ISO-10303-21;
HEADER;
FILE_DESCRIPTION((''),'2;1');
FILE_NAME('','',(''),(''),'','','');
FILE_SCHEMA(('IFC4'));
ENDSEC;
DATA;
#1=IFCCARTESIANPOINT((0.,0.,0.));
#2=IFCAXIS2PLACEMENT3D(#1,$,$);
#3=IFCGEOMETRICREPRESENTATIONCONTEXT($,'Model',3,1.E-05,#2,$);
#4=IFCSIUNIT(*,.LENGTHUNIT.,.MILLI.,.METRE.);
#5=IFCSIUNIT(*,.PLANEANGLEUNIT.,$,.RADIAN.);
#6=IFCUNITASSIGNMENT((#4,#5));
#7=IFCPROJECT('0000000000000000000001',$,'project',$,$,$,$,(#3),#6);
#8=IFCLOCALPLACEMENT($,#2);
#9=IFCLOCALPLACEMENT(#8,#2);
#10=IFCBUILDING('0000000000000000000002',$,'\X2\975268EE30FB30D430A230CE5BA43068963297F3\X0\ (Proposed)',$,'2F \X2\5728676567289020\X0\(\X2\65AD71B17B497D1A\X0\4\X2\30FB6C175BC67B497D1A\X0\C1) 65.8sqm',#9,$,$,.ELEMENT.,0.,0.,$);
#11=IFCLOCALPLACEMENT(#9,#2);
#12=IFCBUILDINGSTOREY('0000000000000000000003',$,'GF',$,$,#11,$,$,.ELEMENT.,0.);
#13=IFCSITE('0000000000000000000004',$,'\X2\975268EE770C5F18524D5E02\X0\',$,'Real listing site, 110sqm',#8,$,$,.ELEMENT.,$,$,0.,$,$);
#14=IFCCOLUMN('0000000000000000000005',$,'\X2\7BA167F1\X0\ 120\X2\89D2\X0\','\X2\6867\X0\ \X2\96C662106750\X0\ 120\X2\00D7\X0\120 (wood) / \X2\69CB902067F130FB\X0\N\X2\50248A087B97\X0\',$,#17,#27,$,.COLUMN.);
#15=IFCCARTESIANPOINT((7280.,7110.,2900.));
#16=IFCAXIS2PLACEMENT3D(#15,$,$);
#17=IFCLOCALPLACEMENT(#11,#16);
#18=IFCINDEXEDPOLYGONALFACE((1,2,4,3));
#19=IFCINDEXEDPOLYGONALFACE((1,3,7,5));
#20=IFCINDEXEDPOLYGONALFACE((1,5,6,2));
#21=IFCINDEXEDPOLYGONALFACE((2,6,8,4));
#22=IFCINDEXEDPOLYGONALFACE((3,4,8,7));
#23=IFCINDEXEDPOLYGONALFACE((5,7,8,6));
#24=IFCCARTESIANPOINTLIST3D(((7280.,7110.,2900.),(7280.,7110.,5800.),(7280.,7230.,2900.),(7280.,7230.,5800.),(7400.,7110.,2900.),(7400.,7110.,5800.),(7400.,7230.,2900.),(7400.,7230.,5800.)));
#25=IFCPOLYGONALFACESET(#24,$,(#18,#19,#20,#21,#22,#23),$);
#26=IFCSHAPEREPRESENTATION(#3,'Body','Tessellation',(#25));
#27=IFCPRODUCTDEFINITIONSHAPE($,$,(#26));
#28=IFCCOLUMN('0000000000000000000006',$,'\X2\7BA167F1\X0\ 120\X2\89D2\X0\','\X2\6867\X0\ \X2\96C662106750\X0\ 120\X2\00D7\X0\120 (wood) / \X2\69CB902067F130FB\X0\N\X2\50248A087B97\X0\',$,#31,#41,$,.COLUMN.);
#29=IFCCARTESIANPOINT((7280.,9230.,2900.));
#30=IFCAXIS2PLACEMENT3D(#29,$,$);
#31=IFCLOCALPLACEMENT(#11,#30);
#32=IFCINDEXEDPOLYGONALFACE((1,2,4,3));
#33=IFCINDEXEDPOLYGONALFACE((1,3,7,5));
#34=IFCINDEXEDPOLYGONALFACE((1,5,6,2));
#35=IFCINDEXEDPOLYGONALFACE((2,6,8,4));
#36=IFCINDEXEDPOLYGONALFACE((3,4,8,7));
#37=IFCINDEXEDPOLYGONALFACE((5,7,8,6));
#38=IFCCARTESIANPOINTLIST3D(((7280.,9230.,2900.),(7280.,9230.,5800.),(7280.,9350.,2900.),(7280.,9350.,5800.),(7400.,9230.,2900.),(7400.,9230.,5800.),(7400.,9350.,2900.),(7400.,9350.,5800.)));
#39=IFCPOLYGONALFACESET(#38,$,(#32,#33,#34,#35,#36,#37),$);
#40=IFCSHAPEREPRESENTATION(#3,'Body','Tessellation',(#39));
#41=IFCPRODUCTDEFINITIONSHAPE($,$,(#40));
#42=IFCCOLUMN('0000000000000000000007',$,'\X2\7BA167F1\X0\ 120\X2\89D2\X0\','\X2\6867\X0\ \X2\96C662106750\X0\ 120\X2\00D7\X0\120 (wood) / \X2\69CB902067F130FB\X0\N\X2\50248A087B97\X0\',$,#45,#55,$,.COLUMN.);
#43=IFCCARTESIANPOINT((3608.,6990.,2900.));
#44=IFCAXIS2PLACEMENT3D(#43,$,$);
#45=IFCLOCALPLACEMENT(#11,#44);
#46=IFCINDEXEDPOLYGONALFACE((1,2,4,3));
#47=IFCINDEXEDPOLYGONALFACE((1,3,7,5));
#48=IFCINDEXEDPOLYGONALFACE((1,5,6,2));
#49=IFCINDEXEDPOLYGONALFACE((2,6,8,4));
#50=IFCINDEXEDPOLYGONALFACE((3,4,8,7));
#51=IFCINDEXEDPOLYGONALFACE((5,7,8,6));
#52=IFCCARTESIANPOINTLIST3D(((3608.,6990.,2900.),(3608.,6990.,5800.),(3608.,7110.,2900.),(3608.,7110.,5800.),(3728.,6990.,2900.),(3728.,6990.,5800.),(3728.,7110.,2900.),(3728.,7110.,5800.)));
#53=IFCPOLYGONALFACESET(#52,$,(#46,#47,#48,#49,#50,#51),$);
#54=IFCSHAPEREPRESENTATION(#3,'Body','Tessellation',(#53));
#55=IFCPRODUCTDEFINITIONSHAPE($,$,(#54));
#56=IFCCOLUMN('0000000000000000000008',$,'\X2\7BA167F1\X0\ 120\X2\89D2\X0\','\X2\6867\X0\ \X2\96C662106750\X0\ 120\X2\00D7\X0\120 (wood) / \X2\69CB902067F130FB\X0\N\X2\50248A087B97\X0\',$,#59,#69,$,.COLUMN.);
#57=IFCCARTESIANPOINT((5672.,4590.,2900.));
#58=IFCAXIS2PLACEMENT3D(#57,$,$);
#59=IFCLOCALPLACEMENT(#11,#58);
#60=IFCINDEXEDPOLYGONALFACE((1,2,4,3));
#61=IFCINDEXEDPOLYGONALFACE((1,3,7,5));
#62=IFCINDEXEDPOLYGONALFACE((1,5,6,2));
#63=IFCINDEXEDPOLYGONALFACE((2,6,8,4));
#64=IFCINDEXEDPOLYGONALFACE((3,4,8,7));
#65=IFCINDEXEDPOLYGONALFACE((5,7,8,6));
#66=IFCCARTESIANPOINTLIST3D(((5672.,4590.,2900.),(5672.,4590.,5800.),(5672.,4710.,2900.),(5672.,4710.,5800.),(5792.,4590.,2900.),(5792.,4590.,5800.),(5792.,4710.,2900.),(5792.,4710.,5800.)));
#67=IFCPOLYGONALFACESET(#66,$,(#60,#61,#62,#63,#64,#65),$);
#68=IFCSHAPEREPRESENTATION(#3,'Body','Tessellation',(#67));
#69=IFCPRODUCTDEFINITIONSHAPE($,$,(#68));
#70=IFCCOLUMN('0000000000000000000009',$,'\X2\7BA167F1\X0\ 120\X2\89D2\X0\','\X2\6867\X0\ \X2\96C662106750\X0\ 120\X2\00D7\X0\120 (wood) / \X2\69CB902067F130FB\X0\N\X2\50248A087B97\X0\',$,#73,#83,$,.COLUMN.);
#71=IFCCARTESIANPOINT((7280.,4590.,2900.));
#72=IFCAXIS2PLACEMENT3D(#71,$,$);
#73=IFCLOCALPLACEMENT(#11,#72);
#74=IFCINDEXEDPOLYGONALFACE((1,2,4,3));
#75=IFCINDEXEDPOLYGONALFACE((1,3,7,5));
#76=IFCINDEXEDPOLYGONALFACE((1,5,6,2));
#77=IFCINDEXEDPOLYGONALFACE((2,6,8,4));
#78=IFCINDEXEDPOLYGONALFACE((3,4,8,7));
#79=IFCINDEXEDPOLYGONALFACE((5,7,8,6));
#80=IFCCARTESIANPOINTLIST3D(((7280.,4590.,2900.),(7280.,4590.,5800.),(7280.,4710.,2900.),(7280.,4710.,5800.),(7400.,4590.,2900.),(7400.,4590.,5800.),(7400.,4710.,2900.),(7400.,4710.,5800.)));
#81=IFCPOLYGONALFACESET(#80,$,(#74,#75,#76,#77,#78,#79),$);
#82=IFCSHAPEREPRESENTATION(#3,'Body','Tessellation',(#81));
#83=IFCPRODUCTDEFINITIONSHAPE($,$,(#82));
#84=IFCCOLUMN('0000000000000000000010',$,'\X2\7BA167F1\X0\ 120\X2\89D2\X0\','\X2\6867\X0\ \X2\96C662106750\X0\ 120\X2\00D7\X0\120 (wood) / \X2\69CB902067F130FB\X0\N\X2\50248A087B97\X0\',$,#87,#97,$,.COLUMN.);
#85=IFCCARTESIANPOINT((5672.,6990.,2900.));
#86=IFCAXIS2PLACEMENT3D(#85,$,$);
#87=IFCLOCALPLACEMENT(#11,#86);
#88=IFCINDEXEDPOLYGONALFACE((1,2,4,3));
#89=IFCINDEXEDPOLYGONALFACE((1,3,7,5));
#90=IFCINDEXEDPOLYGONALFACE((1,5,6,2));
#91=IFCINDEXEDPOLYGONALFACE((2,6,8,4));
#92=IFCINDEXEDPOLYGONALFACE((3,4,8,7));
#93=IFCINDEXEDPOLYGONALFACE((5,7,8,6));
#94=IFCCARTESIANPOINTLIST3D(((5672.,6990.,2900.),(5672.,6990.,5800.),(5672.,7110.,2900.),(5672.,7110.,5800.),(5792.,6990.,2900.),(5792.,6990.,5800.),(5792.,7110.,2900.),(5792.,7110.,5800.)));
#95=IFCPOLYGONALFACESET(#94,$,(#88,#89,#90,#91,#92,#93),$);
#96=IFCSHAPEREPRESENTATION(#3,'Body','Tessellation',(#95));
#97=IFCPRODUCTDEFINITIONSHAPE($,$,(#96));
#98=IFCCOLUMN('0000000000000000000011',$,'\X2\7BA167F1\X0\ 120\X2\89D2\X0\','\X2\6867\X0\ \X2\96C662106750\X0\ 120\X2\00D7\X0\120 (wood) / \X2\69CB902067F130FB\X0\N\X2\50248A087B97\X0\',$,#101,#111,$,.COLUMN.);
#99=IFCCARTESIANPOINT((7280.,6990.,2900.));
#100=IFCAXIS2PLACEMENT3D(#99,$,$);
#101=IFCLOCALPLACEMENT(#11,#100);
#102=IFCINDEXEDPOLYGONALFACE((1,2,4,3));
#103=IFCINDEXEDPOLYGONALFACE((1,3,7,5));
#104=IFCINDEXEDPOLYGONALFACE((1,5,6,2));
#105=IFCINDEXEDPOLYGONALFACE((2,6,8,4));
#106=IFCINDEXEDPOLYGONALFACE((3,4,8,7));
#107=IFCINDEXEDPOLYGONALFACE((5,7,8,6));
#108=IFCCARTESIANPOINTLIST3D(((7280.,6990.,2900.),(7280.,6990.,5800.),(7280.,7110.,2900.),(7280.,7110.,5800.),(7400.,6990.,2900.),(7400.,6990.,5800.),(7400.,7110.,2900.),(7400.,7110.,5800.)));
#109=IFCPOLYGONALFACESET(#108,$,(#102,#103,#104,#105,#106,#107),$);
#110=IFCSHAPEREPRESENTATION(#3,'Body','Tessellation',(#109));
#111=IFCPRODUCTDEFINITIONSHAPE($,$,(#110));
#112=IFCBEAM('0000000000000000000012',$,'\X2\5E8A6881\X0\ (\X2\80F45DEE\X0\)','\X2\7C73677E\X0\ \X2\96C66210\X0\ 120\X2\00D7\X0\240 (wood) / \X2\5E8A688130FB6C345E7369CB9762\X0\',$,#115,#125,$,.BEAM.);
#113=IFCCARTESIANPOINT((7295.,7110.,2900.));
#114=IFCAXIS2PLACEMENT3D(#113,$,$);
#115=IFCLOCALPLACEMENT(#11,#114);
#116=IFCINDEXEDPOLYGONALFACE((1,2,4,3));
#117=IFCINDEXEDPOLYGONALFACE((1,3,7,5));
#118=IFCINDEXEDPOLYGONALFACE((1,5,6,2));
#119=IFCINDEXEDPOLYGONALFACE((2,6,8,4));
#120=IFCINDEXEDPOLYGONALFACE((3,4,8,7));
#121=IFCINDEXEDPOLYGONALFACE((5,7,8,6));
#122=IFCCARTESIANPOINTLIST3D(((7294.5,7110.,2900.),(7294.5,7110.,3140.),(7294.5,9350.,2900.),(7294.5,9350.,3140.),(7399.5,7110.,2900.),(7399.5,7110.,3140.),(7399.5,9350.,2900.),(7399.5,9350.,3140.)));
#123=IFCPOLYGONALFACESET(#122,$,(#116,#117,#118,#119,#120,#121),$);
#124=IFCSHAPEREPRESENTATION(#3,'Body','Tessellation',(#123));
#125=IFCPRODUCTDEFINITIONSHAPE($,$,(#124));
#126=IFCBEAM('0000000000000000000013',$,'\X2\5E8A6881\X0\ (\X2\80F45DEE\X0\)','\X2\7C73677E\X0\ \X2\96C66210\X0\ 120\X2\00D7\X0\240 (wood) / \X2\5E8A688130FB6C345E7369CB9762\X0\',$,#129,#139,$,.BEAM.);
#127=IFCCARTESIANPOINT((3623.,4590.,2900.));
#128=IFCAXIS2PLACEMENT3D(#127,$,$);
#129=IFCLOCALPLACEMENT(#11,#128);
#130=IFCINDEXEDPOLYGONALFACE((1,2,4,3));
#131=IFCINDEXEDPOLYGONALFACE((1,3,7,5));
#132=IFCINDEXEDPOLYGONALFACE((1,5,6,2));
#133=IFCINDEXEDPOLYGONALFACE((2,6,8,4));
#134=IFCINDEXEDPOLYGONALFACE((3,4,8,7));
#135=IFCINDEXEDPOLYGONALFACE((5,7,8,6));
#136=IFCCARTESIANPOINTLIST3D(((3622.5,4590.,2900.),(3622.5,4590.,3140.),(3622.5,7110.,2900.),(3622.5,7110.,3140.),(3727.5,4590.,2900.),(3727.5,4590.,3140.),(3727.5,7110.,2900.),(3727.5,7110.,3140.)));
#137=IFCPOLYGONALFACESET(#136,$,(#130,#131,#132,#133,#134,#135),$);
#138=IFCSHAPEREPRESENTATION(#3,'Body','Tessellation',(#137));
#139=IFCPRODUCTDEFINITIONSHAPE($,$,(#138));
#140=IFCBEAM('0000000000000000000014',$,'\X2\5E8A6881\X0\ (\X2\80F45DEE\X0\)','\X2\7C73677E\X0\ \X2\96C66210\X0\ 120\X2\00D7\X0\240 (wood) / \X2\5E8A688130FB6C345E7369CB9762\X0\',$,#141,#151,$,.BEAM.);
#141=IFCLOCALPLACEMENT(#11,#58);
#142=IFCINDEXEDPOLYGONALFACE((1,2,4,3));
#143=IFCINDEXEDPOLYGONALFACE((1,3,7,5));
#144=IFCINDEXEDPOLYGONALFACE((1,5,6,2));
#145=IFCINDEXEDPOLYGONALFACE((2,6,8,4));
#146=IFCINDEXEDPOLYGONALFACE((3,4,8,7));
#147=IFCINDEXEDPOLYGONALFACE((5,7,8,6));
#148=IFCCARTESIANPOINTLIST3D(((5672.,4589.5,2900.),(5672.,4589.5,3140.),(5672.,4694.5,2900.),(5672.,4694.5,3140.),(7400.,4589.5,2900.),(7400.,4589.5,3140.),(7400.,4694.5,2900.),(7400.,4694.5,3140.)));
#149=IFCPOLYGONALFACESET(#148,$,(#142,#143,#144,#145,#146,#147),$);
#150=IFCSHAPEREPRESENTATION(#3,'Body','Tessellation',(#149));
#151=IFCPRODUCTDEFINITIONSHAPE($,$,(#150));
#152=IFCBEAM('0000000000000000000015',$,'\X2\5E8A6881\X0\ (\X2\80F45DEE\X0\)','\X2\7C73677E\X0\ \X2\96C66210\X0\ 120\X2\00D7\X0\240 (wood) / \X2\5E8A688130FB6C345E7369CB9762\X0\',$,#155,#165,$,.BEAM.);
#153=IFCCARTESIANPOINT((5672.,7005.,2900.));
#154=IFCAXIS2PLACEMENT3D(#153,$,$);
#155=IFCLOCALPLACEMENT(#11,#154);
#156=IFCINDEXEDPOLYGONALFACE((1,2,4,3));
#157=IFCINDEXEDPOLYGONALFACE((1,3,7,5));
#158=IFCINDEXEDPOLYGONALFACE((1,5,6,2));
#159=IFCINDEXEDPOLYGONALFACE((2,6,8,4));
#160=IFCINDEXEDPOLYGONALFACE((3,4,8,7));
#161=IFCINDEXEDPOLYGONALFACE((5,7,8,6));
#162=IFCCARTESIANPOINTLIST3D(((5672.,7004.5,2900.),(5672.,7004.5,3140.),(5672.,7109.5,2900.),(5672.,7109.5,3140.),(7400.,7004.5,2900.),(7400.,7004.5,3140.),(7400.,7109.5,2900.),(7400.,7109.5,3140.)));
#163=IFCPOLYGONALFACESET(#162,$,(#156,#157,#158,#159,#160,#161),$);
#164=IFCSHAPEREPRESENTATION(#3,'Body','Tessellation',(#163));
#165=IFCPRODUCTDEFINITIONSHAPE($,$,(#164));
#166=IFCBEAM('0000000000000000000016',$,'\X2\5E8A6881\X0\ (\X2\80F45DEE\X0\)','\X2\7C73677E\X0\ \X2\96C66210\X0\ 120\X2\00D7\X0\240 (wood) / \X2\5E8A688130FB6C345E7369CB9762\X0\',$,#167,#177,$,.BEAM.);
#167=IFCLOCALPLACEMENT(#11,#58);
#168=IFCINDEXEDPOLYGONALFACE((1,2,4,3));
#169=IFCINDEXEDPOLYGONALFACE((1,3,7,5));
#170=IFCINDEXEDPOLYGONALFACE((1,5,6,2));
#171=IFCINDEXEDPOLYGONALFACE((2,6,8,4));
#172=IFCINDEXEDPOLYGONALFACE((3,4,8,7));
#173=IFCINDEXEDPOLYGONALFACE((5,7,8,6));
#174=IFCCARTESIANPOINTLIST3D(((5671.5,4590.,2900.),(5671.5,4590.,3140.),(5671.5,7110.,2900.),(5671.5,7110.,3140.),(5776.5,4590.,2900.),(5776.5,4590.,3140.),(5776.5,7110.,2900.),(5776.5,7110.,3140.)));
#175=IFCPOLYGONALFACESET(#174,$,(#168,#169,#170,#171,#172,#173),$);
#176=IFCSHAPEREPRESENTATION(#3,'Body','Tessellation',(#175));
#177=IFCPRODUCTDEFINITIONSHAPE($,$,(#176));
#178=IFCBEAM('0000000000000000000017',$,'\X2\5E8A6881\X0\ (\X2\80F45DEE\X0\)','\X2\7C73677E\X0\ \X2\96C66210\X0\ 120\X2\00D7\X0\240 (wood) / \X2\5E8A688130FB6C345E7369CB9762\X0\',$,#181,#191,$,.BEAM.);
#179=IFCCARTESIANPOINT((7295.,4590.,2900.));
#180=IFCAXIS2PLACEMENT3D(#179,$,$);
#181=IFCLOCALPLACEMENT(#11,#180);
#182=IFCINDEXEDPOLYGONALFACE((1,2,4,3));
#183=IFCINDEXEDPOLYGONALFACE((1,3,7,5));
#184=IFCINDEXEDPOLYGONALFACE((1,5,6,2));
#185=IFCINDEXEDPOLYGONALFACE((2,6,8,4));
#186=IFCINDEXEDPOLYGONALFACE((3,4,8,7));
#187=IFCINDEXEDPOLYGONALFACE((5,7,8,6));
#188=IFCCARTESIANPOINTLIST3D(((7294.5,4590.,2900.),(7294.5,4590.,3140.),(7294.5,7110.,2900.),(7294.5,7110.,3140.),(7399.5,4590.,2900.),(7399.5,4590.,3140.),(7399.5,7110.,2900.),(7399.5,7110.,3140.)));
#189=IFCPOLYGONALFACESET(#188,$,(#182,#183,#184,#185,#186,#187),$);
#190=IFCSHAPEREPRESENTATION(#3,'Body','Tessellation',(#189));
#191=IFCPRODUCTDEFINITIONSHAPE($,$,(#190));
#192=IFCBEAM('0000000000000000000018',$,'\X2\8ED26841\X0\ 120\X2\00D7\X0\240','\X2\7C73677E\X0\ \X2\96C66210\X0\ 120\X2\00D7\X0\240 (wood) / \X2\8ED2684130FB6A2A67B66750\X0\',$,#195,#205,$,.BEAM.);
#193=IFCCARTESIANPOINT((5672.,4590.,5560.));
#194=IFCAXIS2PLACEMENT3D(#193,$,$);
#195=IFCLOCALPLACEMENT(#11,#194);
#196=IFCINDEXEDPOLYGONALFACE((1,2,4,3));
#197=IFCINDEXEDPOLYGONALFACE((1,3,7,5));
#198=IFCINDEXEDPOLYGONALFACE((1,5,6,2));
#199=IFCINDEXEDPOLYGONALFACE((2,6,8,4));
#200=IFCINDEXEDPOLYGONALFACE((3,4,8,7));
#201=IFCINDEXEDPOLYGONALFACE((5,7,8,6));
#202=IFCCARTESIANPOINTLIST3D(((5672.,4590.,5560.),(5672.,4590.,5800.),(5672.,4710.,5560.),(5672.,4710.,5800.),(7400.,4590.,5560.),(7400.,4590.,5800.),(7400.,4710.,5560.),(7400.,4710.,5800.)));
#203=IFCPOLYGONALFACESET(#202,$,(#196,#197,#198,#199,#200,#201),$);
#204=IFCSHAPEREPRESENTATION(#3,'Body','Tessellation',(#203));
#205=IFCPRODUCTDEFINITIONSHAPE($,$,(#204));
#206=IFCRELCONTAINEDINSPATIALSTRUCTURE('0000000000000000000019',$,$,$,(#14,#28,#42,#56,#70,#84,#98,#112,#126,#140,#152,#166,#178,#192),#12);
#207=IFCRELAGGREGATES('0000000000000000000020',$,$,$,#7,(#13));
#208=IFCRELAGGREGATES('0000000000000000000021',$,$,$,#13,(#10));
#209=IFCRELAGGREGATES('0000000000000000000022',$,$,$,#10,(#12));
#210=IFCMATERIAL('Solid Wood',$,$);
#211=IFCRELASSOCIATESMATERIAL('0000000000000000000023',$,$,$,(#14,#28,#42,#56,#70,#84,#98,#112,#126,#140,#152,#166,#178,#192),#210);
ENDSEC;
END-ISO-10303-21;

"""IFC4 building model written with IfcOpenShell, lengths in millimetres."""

from ifc_helpers import new_model, si_unit, frame, frame_2d, origin, place, context, project, spatial, rectangle, extrude, material, element, save


model = new_model("IFC4")

# Units and contexts
model_context = context("Model", 3, precision=1e-05, world=origin())
ifc_project = project(units=[si_unit("LENGTHUNIT", "METRE", prefix="MILLI"), si_unit("PLANEANGLEUNIT", "RADIAN")], contexts=[model_context])

# Site, building, storey
site_placement = place(None, origin())
site = spatial("IfcSite", under=ifc_project, at=site_placement, Name="青森県弘前市", ObjectType="Real listing site, 110sqm", CompositionType="ELEMENT", RefElevation=0.0)
building_placement = place(site_placement, origin())
building = spatial("IfcBuilding", under=site, at=building_placement, Name="青森・ピアノ室と防音 (Proposed)", ObjectType="2F 在来木造(断熱等級4・気密等級C1) 65.8sqm", CompositionType="ELEMENT", ElevationOfRefHeight=0.0, ElevationOfTerrain=0.0)
storey_placement = place(building_placement, origin())
storey = spatial("IfcBuildingStorey", under=building, at=storey_placement, Name="GF", CompositionType="ELEMENT", Elevation=0.0)

# Columns
ifc_material_1 = material(Name="Solid Wood")
column_1_placement = place(storey_placement, frame((7280.0, 7110.0, 2900.0)))
element("IfcColumn", 1, at=column_1_placement, inside=storey, material=ifc_material_1, Name="管柱 120角", Description="桧 集成材 120×120 (wood) / 構造柱・N値計算", PredefinedType="COLUMN", context=model_context, shape_type="SweptSolid", body=[
    extrude(rectangle(XDim=120.0, YDim=120.0, at=frame_2d((60.0, 60.0))), frame((7280.0, 7110.0, 2900.0)), (0.0, 0.0, 1.0), 2900.0),
])
column_2_placement = place(storey_placement, frame((7280.0, 9230.0, 2900.0)))
element("IfcColumn", 2, at=column_2_placement, inside=storey, material=ifc_material_1, Name="管柱 120角", Description="桧 集成材 120×120 (wood) / 構造柱・N値計算", PredefinedType="COLUMN", context=model_context, shape_type="SweptSolid", body=[
    extrude(rectangle(XDim=120.0, YDim=120.0, at=frame_2d((60.0, 60.0))), frame((7280.0, 9230.0, 2900.0)), (0.0, 0.0, 1.0), 2900.0),
])
column_3_placement = place(storey_placement, frame((3608.0, 6990.0, 2900.0)))
element("IfcColumn", 3, at=column_3_placement, inside=storey, material=ifc_material_1, Name="管柱 120角", Description="桧 集成材 120×120 (wood) / 構造柱・N値計算", PredefinedType="COLUMN", context=model_context, shape_type="SweptSolid", body=[
    extrude(rectangle(XDim=120.0, YDim=120.0, at=frame_2d((60.0, 60.0))), frame((3608.0, 6990.0, 2900.0)), (0.0, 0.0, 1.0), 2900.0),
])
column_4_placement = place(storey_placement, frame((5672.0, 4590.0, 2900.0)))
element("IfcColumn", 4, at=column_4_placement, inside=storey, material=ifc_material_1, Name="管柱 120角", Description="桧 集成材 120×120 (wood) / 構造柱・N値計算", PredefinedType="COLUMN", context=model_context, shape_type="SweptSolid", body=[
    extrude(rectangle(XDim=120.0, YDim=120.0, at=frame_2d((60.0, 60.0))), frame((5672.0, 4590.0, 2900.0)), (0.0, 0.0, 1.0), 2900.0),
])
column_5_placement = place(storey_placement, frame((7280.0, 4590.0, 2900.0)))
element("IfcColumn", 5, at=column_5_placement, inside=storey, material=ifc_material_1, Name="管柱 120角", Description="桧 集成材 120×120 (wood) / 構造柱・N値計算", PredefinedType="COLUMN", context=model_context, shape_type="SweptSolid", body=[
    extrude(rectangle(XDim=120.0, YDim=120.0, at=frame_2d((60.0, 60.0))), frame((7280.0, 4590.0, 2900.0)), (0.0, 0.0, 1.0), 2900.0),
])
column_6_placement = place(storey_placement, frame((5672.0, 6990.0, 2900.0)))
element("IfcColumn", 6, at=column_6_placement, inside=storey, material=ifc_material_1, Name="管柱 120角", Description="桧 集成材 120×120 (wood) / 構造柱・N値計算", PredefinedType="COLUMN", context=model_context, shape_type="SweptSolid", body=[
    extrude(rectangle(XDim=120.0, YDim=120.0, at=frame_2d((60.0, 60.0))), frame((5672.0, 6990.0, 2900.0)), (0.0, 0.0, 1.0), 2900.0),
])
column_7_placement = place(storey_placement, frame((7280.0, 6990.0, 2900.0)))
element("IfcColumn", 7, at=column_7_placement, inside=storey, material=ifc_material_1, Name="管柱 120角", Description="桧 集成材 120×120 (wood) / 構造柱・N値計算", PredefinedType="COLUMN", context=model_context, shape_type="SweptSolid", body=[
    extrude(rectangle(XDim=120.0, YDim=120.0, at=frame_2d((60.0, 60.0))), frame((7280.0, 6990.0, 2900.0)), (0.0, 0.0, 1.0), 2900.0),
])

# Beams
beam_1_placement = place(storey_placement, frame((7295.0, 7110.0, 2900.0)))
element("IfcBeam", 8, at=beam_1_placement, inside=storey, material=ifc_material_1, Name="床梁 (胴差)", Description="米松 集成 120×240 (wood) / 床梁・水平構面", PredefinedType="BEAM", context=model_context, shape_type="SweptSolid", body=[
    extrude(rectangle(XDim=105.0, YDim=2240.0, at=frame_2d((52.0, 1120.0))), frame((7295.0, 7110.0, 2900.0)), (0.0, 0.0, 1.0), 240.0),
])
beam_2_placement = place(storey_placement, frame((3623.0, 4590.0, 2900.0)))
element("IfcBeam", 9, at=beam_2_placement, inside=storey, material=ifc_material_1, Name="床梁 (胴差)", Description="米松 集成 120×240 (wood) / 床梁・水平構面", PredefinedType="BEAM", context=model_context, shape_type="SweptSolid", body=[
    extrude(rectangle(XDim=105.0, YDim=2520.0, at=frame_2d((52.0, 1260.0))), frame((3623.0, 4590.0, 2900.0)), (0.0, 0.0, 1.0), 240.0),
])
beam_3_placement = place(storey_placement, frame((5672.0, 4590.0, 2900.0)))
element("IfcBeam", 10, at=beam_3_placement, inside=storey, material=ifc_material_1, Name="床梁 (胴差)", Description="米松 集成 120×240 (wood) / 床梁・水平構面", PredefinedType="BEAM", context=model_context, shape_type="SweptSolid", body=[
    extrude(rectangle(XDim=1728.0, YDim=105.0, at=frame_2d((864.0, 52.0))), frame((5672.0, 4590.0, 2900.0)), (0.0, 0.0, 1.0), 240.0),
])
beam_4_placement = place(storey_placement, frame((5672.0, 7005.0, 2900.0)))
element("IfcBeam", 11, at=beam_4_placement, inside=storey, material=ifc_material_1, Name="床梁 (胴差)", Description="米松 集成 120×240 (wood) / 床梁・水平構面", PredefinedType="BEAM", context=model_context, shape_type="SweptSolid", body=[
    extrude(rectangle(XDim=1728.0, YDim=105.0, at=frame_2d((864.0, 52.0))), frame((5672.0, 7005.0, 2900.0)), (0.0, 0.0, 1.0), 240.0),
])
beam_5_placement = place(storey_placement, frame((5672.0, 4590.0, 2900.0)))
element("IfcBeam", 12, at=beam_5_placement, inside=storey, material=ifc_material_1, Name="床梁 (胴差)", Description="米松 集成 120×240 (wood) / 床梁・水平構面", PredefinedType="BEAM", context=model_context, shape_type="SweptSolid", body=[
    extrude(rectangle(XDim=105.0, YDim=2520.0, at=frame_2d((52.0, 1260.0))), frame((5672.0, 4590.0, 2900.0)), (0.0, 0.0, 1.0), 240.0),
])
beam_6_placement = place(storey_placement, frame((7295.0, 4590.0, 2900.0)))
element("IfcBeam", 13, at=beam_6_placement, inside=storey, material=ifc_material_1, Name="床梁 (胴差)", Description="米松 集成 120×240 (wood) / 床梁・水平構面", PredefinedType="BEAM", context=model_context, shape_type="SweptSolid", body=[
    extrude(rectangle(XDim=105.0, YDim=2520.0, at=frame_2d((52.0, 1260.0))), frame((7295.0, 4590.0, 2900.0)), (0.0, 0.0, 1.0), 240.0),
])
beam_7_placement = place(storey_placement, frame((5672.0, 4590.0, 5560.0)))
element("IfcBeam", 14, at=beam_7_placement, inside=storey, material=ifc_material_1, Name="軒桁 120×240", Description="米松 集成 120×240 (wood) / 軒桁・横架材", PredefinedType="BEAM", context=model_context, shape_type="SweptSolid", body=[
    extrude(rectangle(XDim=1728.0, YDim=120.0, at=frame_2d((864.0, 60.0))), frame((5672.0, 4590.0, 5560.0)), (0.0, 0.0, 1.0), 240.0),
])

save(model, "model.ifc")
